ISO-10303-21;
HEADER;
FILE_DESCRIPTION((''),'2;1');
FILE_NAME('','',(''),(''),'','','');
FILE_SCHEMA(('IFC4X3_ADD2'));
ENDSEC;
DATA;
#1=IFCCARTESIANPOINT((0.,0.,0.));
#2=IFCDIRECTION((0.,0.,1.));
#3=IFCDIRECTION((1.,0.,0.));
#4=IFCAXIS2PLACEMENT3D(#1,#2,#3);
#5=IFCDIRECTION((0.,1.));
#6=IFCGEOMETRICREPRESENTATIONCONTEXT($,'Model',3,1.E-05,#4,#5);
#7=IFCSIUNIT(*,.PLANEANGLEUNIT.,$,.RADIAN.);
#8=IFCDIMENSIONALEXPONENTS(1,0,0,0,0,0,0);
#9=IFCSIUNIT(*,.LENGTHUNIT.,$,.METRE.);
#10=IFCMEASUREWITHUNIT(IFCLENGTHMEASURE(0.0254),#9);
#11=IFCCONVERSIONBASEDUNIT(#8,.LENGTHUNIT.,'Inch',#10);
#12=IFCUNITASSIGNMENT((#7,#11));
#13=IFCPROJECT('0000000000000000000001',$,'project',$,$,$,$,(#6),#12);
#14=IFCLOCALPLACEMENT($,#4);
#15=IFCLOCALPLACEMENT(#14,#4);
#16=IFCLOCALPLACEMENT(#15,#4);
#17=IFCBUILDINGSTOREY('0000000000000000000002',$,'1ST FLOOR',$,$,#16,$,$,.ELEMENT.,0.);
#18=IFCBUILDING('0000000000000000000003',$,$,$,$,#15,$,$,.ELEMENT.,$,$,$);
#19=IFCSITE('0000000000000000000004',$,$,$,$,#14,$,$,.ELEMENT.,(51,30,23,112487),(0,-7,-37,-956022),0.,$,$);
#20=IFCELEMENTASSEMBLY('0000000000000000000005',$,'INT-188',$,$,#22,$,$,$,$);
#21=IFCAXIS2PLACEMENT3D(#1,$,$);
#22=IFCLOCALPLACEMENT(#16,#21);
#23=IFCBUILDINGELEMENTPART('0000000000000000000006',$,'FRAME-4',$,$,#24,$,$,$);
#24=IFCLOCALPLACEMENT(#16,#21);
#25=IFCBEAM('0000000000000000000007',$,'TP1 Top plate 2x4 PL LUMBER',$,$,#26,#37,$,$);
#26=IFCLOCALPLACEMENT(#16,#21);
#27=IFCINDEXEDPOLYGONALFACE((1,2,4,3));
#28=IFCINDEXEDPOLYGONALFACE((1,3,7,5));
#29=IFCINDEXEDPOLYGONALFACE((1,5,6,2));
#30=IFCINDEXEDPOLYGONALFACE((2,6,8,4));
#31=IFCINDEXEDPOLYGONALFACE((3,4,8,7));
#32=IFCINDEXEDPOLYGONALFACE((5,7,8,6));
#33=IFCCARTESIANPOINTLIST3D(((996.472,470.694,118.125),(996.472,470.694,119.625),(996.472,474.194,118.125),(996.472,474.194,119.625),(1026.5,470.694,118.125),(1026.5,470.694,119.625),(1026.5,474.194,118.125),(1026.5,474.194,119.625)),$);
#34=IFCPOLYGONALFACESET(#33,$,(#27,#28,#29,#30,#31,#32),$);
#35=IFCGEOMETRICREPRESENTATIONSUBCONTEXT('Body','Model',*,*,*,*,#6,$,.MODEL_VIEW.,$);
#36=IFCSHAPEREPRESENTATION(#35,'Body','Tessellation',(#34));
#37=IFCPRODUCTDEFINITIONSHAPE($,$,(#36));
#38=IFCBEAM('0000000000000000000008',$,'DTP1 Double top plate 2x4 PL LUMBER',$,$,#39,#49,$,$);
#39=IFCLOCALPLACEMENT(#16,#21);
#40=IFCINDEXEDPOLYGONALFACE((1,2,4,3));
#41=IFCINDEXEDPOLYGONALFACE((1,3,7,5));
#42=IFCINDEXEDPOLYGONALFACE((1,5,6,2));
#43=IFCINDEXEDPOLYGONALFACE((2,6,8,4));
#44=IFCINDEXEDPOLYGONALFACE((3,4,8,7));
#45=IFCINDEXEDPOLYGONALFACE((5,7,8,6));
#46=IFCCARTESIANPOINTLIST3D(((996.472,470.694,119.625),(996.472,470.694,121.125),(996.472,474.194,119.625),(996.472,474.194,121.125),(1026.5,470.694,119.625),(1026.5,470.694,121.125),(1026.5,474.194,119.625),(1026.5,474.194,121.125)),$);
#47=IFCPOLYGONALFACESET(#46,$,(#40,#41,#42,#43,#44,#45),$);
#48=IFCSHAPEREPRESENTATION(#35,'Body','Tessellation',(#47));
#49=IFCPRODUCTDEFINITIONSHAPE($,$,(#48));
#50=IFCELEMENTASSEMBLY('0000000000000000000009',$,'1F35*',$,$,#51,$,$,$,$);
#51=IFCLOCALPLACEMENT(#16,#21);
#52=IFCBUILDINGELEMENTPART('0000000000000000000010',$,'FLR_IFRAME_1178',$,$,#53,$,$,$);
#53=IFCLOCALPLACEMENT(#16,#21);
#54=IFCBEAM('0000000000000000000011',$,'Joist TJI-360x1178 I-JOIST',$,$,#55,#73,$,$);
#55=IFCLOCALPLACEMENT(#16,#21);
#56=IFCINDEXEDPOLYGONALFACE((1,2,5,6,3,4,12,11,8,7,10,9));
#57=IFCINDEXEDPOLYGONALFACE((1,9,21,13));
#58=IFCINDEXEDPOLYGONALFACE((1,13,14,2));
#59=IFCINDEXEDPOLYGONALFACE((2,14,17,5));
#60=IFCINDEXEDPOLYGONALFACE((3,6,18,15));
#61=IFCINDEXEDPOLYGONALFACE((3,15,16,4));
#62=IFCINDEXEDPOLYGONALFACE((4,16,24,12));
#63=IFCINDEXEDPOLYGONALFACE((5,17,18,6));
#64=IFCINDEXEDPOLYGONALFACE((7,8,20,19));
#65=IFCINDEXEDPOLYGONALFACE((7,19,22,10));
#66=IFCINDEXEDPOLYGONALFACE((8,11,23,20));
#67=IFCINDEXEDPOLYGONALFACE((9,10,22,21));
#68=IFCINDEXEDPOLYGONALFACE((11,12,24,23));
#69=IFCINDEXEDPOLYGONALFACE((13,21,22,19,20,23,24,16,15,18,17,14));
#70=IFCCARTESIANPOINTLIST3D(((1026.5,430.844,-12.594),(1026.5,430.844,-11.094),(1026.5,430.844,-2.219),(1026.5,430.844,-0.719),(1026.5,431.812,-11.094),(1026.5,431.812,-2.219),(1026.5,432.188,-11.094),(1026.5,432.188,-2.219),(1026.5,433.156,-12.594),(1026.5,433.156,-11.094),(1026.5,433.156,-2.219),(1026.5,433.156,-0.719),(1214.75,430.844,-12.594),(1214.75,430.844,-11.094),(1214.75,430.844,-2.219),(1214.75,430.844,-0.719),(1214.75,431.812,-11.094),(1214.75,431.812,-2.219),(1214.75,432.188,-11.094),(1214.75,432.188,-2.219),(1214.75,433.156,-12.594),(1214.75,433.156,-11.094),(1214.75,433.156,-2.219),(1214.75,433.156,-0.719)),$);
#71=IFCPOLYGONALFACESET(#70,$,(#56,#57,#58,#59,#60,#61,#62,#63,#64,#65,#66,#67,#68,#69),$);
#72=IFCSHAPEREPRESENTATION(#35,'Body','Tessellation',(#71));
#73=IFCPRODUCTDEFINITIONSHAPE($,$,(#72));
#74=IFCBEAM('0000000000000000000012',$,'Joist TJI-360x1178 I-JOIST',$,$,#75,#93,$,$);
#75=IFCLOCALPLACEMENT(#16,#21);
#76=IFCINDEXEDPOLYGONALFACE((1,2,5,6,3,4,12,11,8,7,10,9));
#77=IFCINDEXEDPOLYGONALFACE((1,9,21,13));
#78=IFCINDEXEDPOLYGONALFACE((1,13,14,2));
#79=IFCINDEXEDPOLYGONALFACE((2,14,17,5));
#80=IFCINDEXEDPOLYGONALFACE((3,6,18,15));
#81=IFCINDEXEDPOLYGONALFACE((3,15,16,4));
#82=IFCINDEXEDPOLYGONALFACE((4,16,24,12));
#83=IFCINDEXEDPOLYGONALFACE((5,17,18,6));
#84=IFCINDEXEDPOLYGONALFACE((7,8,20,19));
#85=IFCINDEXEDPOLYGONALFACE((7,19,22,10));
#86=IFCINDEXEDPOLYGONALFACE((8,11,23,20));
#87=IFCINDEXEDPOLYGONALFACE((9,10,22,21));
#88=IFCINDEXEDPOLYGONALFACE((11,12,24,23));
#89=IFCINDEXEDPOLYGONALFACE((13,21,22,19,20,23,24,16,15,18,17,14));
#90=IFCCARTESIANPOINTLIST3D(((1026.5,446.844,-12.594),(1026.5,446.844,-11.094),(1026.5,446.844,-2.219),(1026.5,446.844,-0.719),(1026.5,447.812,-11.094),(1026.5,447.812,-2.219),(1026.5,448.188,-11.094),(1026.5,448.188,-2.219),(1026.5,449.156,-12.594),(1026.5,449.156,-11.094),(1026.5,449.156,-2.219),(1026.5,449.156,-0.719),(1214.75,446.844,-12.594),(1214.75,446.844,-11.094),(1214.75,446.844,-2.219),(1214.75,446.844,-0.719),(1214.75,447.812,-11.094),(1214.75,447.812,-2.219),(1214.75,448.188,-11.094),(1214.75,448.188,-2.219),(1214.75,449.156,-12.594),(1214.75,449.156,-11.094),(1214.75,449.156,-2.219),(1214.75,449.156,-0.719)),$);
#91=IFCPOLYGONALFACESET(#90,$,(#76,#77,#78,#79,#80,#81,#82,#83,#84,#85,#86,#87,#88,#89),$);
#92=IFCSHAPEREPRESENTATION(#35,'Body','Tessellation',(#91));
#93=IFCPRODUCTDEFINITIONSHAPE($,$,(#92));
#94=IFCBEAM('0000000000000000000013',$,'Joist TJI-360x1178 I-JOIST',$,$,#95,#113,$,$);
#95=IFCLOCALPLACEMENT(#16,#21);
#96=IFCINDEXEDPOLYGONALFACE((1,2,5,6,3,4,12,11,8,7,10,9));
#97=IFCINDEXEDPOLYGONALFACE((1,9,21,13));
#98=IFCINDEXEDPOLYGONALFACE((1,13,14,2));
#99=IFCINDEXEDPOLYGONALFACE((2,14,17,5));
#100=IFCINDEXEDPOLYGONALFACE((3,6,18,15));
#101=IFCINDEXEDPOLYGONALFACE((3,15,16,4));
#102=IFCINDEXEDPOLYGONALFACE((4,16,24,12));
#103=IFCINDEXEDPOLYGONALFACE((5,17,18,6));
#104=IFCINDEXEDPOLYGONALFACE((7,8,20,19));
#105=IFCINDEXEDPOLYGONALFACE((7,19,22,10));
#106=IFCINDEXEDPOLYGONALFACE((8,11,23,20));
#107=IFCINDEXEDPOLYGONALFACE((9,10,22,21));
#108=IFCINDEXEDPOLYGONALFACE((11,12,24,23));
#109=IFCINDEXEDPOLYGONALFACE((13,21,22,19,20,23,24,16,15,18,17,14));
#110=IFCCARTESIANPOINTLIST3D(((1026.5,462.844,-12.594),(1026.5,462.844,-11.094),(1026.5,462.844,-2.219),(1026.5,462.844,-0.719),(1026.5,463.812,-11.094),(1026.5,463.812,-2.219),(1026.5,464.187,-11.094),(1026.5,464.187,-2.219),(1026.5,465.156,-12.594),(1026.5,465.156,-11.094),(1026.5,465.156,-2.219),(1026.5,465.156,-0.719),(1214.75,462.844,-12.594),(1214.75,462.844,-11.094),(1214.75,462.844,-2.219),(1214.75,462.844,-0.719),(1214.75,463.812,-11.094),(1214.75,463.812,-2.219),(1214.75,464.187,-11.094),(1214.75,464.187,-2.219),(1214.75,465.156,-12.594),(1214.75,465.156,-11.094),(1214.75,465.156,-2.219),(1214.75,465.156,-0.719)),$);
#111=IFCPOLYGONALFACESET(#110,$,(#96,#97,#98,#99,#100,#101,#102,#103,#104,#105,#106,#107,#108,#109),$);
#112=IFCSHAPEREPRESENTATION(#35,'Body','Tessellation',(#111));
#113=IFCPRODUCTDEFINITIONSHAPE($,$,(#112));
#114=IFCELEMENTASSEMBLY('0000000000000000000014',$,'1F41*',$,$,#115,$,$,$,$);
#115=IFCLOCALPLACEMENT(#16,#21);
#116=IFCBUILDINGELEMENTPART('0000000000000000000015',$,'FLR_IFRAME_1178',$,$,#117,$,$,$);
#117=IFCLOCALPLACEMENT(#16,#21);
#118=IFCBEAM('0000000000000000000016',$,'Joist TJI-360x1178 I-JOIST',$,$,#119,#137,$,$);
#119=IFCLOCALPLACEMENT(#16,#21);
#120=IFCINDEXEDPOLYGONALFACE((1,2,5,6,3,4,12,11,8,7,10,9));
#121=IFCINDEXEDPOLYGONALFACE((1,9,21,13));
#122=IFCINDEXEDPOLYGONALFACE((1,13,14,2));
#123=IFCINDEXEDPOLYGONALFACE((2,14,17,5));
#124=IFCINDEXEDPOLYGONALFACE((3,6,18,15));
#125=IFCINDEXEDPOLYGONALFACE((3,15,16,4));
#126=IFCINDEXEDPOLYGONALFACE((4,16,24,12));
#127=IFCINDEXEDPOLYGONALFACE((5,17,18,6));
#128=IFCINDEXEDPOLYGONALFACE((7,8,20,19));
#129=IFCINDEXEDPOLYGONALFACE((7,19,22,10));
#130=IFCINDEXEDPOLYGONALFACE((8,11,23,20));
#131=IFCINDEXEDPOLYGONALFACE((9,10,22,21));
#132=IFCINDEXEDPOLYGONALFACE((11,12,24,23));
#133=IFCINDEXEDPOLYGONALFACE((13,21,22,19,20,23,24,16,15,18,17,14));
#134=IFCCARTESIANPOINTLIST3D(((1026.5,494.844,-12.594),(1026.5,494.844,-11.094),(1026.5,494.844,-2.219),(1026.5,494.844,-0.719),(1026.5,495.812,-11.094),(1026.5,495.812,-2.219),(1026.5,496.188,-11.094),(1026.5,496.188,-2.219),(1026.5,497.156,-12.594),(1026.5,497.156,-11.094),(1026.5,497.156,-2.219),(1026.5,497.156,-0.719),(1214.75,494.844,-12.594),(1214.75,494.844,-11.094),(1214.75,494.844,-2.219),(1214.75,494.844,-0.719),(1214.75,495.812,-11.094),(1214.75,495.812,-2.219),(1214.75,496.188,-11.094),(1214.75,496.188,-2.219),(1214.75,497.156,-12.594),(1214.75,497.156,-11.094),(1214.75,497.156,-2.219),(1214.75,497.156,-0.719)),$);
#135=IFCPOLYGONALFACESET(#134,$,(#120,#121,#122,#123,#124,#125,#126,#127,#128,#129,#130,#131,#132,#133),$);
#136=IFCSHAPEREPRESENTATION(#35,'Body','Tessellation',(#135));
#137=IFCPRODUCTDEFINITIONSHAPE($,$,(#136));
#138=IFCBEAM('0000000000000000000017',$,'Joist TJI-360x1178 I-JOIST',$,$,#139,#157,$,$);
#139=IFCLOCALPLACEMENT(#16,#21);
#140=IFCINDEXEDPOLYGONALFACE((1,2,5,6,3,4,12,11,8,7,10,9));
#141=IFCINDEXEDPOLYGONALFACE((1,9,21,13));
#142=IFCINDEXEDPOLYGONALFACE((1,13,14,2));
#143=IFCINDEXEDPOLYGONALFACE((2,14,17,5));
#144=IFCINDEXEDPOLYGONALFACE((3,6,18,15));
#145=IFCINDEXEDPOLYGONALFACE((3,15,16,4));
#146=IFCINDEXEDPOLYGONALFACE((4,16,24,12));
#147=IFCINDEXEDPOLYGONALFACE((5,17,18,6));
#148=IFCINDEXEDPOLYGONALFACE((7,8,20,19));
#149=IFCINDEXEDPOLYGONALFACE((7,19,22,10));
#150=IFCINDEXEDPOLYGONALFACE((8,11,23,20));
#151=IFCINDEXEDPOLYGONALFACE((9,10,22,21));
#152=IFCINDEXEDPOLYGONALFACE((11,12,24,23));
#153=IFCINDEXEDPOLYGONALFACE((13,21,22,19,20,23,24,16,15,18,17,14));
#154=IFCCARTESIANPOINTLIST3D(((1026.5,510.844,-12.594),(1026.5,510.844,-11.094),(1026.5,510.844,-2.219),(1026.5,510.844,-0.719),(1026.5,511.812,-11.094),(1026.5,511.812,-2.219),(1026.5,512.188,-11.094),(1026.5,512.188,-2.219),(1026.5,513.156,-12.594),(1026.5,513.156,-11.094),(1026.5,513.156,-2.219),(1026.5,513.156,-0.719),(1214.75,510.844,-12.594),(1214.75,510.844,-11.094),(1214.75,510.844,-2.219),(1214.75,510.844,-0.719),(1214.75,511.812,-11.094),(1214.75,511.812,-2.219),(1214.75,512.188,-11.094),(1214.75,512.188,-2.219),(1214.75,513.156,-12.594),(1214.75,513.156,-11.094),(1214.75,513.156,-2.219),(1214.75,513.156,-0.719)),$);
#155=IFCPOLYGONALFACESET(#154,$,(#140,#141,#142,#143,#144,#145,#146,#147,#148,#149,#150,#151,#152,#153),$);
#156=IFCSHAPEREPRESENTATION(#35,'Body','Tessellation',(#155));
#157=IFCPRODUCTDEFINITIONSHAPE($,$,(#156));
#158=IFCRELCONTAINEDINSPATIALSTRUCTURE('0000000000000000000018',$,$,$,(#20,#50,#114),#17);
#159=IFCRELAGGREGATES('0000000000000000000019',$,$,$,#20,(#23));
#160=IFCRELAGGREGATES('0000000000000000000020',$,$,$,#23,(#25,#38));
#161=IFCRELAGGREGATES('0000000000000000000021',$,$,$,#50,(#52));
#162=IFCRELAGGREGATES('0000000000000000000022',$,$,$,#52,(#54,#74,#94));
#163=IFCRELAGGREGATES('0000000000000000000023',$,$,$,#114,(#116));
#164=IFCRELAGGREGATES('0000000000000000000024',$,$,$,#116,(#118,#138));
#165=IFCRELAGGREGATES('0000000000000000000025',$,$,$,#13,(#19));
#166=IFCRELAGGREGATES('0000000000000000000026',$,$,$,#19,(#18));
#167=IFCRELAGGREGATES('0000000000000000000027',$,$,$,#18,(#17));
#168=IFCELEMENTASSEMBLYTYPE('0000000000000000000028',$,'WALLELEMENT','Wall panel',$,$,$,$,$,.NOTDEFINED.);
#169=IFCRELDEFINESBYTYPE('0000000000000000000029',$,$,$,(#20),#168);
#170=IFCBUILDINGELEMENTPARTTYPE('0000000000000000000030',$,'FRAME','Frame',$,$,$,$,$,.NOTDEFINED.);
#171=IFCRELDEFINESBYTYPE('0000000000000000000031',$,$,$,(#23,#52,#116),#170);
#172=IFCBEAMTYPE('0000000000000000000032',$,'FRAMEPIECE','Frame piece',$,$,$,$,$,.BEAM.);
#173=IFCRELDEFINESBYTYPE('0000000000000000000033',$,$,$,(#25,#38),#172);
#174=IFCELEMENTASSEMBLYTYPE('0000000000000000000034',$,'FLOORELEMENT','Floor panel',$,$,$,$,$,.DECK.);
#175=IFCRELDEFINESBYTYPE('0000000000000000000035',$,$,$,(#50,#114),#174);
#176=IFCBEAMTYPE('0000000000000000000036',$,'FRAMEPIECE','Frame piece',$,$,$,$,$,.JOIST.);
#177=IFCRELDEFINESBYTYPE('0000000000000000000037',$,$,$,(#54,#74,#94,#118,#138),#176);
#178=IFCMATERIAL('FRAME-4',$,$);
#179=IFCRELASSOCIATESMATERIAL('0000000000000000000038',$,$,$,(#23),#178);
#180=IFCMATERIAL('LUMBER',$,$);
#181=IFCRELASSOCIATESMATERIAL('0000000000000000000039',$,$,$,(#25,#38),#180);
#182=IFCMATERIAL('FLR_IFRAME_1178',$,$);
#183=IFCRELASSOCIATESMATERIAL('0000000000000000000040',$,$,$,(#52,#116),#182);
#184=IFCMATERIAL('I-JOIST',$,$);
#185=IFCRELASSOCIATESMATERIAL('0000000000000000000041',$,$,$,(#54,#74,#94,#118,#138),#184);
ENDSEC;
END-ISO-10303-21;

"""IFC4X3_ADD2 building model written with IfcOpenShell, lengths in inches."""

from ifc_helpers import new_model, entity, si_unit, converted_unit, direction, frame, origin_with_axes, origin_2d_with_axis, place, context, subcontext, project, spatial, rectangle, i_section, extrude, material, type_object, element, aggregate, save


model = new_model("IFC4X3_ADD2")

# Units and contexts
model_context = context("Model", 3, precision=1e-05, world=origin_with_axes(), true_north=direction((0.0, 1.0)))
body_context = subcontext(model_context, "Body", "Model", "MODEL_VIEW")
ifc_project = project(units=[si_unit("PLANEANGLEUNIT", "RADIAN"), converted_unit("LENGTHUNIT", "Inch", entity("IfcLengthMeasure", 0.0254), si_unit("LENGTHUNIT", "METRE"), dimensions=[1, 0, 0, 0, 0, 0, 0])], contexts=[model_context])

# Site, building, storey
site_placement = place(None, origin_with_axes())
site = spatial("IfcSite", under=ifc_project, at=site_placement, CompositionType="ELEMENT", RefLatitude=(51, 30, 23, 112487), RefLongitude=(0, -7, -37, -956022), RefElevation=0.0)
building_placement = place(site_placement, origin_with_axes())
building = spatial("IfcBuilding", under=site, at=building_placement, CompositionType="ELEMENT")
storey_placement = place(building_placement, origin_with_axes())
storey = spatial("IfcBuildingStorey", under=building, at=storey_placement, Name="1ST FLOOR", CompositionType="ELEMENT", Elevation=0.0)

# Element assembly, building element part
element_assembly_type_1 = type_object("IfcElementAssemblyType", Name="WALLELEMENT", Description="Wall panel", PredefinedType="NOTDEFINED")
ifc_material_1 = material(Name="FRAME-4")
building_element_part_type = type_object("IfcBuildingElementPartType", Name="FRAME", Description="Frame", PredefinedType="NOTDEFINED")
ifc_material_2 = material(Name="LUMBER")
assembly_1_placement = place(storey_placement, origin_with_axes())
assembly_1 = element("IfcElementAssembly", 1, at=assembly_1_placement, inside=storey, type_object=element_assembly_type_1, Name="INT-188")
building_element_part_1_placement = place(storey_placement, origin_with_axes())
building_element_part_1 = element("IfcBuildingElementPart", 2, at=building_element_part_1_placement, type_object=building_element_part_type, material=ifc_material_1, Name="FRAME-4")
aggregate(assembly_1, [building_element_part_1])

# Shared definitions
beam_type_1 = type_object("IfcBeamType", Name="FRAMEPIECE", Description="Frame piece", PredefinedType="BEAM")

# Beams
beam_1_placement = place(storey_placement, frame((1026.5, 472.444, 118.875), z_axis=(-1.0, 0.0, 0.0), x_axis=(0.0, 0.0, -1.0)))
beam_1 = element("IfcBeam", 3, at=beam_1_placement, type_object=beam_type_1, material=ifc_material_2, Name="TP1 Top plate 2x4 PL LUMBER", context=body_context, shape_type="SweptSolid", body=[
    extrude(rectangle(XDim=1.5, YDim=3.5, at=origin_2d_with_axis()), origin_with_axes(), (0.0, 0.0, 1.0), 30.028),
])
beam_2_placement = place(storey_placement, frame((996.472, 472.444, 120.375), z_axis=(1.0, 0.0, 0.0), x_axis=(0.0, 0.0, 1.0)))
beam_2 = element("IfcBeam", 4, at=beam_2_placement, type_object=beam_type_1, material=ifc_material_2, Name="DTP1 Double top plate 2x4 PL LUMBER", context=body_context, shape_type="SweptSolid", body=[
    extrude(rectangle(XDim=1.5, YDim=3.5, at=origin_2d_with_axis()), origin_with_axes(), (0.0, 0.0, 1.0), 30.028),
])
aggregate(building_element_part_1, [beam_1, beam_2])

# Element assemblies, building element parts, beams
element_assembly_type_2 = type_object("IfcElementAssemblyType", Name="FLOORELEMENT", Description="Floor panel", PredefinedType="DECK")
assembly_2_placement = place(storey_placement, origin_with_axes())
assembly_2 = element("IfcElementAssembly", 5, at=assembly_2_placement, inside=storey, type_object=element_assembly_type_2, Name="1F35*")
ifc_material_3 = material(Name="FLR_IFRAME_1178")
building_element_part_2_placement = place(storey_placement, origin_with_axes())
building_element_part_2 = element("IfcBuildingElementPart", 6, at=building_element_part_2_placement, type_object=building_element_part_type, material=ifc_material_3, Name="FLR_IFRAME_1178")
aggregate(assembly_2, [building_element_part_2])
ifc_material_4 = material(Name="I-JOIST")
beam_type_2 = type_object("IfcBeamType", Name="FRAMEPIECE", Description="Frame piece", PredefinedType="JOIST")
beam_3_placement = place(storey_placement, frame((1026.5, 432.0, -6.656), z_axis=(1.0, 0.0, 0.0), x_axis=(0.0, 1.0, 0.0)))
beam_3 = element("IfcBeam", 7, at=beam_3_placement, type_object=beam_type_2, material=ifc_material_4, Name="Joist TJI-360x1178 I-JOIST", context=body_context, shape_type="SweptSolid", body=[
    extrude(i_section(OverallWidth=2.313, OverallDepth=11.875, WebThickness=0.375, FlangeThickness=1.5, at=origin_2d_with_axis()), origin_with_axes(), (0.0, 0.0, 1.0), 188.25),
])
beam_4_placement = place(storey_placement, frame((1026.5, 448.0, -6.656), z_axis=(1.0, 0.0, 0.0), x_axis=(0.0, 1.0, 0.0)))
beam_4 = element("IfcBeam", 8, at=beam_4_placement, type_object=beam_type_2, material=ifc_material_4, Name="Joist TJI-360x1178 I-JOIST", context=body_context, shape_type="SweptSolid", body=[
    extrude(i_section(OverallWidth=2.313, OverallDepth=11.875, WebThickness=0.375, FlangeThickness=1.5, at=origin_2d_with_axis()), origin_with_axes(), (0.0, 0.0, 1.0), 188.25),
])
beam_5_placement = place(storey_placement, frame((1026.5, 464.0, -6.656), z_axis=(1.0, 0.0, 0.0), x_axis=(0.0, 1.0, 0.0)))
beam_5 = element("IfcBeam", 9, at=beam_5_placement, type_object=beam_type_2, material=ifc_material_4, Name="Joist TJI-360x1178 I-JOIST", context=body_context, shape_type="SweptSolid", body=[
    extrude(i_section(OverallWidth=2.313, OverallDepth=11.875, WebThickness=0.375, FlangeThickness=1.5, at=origin_2d_with_axis()), origin_with_axes(), (0.0, 0.0, 1.0), 188.25),
])
aggregate(building_element_part_2, [beam_3, beam_4, beam_5])
assembly_3_placement = place(storey_placement, origin_with_axes())
assembly_3 = element("IfcElementAssembly", 10, at=assembly_3_placement, inside=storey, type_object=element_assembly_type_2, Name="1F41*")
building_element_part_3_placement = place(storey_placement, origin_with_axes())
building_element_part_3 = element("IfcBuildingElementPart", 11, at=building_element_part_3_placement, type_object=building_element_part_type, material=ifc_material_3, Name="FLR_IFRAME_1178")
aggregate(assembly_3, [building_element_part_3])
beam_6_placement = place(storey_placement, frame((1026.5, 496.0, -6.656), z_axis=(1.0, 0.0, 0.0), x_axis=(0.0, 1.0, 0.0)))
beam_6 = element("IfcBeam", 12, at=beam_6_placement, type_object=beam_type_2, material=ifc_material_4, Name="Joist TJI-360x1178 I-JOIST", context=body_context, shape_type="SweptSolid", body=[
    extrude(i_section(OverallWidth=2.313, OverallDepth=11.875, WebThickness=0.375, FlangeThickness=1.5, at=origin_2d_with_axis()), origin_with_axes(), (0.0, 0.0, 1.0), 188.25),
])
beam_7_placement = place(storey_placement, frame((1026.5, 512.0, -6.656), z_axis=(1.0, 0.0, 0.0), x_axis=(0.0, 1.0, 0.0)))
beam_7 = element("IfcBeam", 13, at=beam_7_placement, type_object=beam_type_2, material=ifc_material_4, Name="Joist TJI-360x1178 I-JOIST", context=body_context, shape_type="SweptSolid", body=[
    extrude(i_section(OverallWidth=2.313, OverallDepth=11.875, WebThickness=0.375, FlangeThickness=1.5, at=origin_2d_with_axis()), origin_with_axes(), (0.0, 0.0, 1.0), 188.25),
])
aggregate(building_element_part_3, [beam_6, beam_7])

save(model, "model.ifc")
